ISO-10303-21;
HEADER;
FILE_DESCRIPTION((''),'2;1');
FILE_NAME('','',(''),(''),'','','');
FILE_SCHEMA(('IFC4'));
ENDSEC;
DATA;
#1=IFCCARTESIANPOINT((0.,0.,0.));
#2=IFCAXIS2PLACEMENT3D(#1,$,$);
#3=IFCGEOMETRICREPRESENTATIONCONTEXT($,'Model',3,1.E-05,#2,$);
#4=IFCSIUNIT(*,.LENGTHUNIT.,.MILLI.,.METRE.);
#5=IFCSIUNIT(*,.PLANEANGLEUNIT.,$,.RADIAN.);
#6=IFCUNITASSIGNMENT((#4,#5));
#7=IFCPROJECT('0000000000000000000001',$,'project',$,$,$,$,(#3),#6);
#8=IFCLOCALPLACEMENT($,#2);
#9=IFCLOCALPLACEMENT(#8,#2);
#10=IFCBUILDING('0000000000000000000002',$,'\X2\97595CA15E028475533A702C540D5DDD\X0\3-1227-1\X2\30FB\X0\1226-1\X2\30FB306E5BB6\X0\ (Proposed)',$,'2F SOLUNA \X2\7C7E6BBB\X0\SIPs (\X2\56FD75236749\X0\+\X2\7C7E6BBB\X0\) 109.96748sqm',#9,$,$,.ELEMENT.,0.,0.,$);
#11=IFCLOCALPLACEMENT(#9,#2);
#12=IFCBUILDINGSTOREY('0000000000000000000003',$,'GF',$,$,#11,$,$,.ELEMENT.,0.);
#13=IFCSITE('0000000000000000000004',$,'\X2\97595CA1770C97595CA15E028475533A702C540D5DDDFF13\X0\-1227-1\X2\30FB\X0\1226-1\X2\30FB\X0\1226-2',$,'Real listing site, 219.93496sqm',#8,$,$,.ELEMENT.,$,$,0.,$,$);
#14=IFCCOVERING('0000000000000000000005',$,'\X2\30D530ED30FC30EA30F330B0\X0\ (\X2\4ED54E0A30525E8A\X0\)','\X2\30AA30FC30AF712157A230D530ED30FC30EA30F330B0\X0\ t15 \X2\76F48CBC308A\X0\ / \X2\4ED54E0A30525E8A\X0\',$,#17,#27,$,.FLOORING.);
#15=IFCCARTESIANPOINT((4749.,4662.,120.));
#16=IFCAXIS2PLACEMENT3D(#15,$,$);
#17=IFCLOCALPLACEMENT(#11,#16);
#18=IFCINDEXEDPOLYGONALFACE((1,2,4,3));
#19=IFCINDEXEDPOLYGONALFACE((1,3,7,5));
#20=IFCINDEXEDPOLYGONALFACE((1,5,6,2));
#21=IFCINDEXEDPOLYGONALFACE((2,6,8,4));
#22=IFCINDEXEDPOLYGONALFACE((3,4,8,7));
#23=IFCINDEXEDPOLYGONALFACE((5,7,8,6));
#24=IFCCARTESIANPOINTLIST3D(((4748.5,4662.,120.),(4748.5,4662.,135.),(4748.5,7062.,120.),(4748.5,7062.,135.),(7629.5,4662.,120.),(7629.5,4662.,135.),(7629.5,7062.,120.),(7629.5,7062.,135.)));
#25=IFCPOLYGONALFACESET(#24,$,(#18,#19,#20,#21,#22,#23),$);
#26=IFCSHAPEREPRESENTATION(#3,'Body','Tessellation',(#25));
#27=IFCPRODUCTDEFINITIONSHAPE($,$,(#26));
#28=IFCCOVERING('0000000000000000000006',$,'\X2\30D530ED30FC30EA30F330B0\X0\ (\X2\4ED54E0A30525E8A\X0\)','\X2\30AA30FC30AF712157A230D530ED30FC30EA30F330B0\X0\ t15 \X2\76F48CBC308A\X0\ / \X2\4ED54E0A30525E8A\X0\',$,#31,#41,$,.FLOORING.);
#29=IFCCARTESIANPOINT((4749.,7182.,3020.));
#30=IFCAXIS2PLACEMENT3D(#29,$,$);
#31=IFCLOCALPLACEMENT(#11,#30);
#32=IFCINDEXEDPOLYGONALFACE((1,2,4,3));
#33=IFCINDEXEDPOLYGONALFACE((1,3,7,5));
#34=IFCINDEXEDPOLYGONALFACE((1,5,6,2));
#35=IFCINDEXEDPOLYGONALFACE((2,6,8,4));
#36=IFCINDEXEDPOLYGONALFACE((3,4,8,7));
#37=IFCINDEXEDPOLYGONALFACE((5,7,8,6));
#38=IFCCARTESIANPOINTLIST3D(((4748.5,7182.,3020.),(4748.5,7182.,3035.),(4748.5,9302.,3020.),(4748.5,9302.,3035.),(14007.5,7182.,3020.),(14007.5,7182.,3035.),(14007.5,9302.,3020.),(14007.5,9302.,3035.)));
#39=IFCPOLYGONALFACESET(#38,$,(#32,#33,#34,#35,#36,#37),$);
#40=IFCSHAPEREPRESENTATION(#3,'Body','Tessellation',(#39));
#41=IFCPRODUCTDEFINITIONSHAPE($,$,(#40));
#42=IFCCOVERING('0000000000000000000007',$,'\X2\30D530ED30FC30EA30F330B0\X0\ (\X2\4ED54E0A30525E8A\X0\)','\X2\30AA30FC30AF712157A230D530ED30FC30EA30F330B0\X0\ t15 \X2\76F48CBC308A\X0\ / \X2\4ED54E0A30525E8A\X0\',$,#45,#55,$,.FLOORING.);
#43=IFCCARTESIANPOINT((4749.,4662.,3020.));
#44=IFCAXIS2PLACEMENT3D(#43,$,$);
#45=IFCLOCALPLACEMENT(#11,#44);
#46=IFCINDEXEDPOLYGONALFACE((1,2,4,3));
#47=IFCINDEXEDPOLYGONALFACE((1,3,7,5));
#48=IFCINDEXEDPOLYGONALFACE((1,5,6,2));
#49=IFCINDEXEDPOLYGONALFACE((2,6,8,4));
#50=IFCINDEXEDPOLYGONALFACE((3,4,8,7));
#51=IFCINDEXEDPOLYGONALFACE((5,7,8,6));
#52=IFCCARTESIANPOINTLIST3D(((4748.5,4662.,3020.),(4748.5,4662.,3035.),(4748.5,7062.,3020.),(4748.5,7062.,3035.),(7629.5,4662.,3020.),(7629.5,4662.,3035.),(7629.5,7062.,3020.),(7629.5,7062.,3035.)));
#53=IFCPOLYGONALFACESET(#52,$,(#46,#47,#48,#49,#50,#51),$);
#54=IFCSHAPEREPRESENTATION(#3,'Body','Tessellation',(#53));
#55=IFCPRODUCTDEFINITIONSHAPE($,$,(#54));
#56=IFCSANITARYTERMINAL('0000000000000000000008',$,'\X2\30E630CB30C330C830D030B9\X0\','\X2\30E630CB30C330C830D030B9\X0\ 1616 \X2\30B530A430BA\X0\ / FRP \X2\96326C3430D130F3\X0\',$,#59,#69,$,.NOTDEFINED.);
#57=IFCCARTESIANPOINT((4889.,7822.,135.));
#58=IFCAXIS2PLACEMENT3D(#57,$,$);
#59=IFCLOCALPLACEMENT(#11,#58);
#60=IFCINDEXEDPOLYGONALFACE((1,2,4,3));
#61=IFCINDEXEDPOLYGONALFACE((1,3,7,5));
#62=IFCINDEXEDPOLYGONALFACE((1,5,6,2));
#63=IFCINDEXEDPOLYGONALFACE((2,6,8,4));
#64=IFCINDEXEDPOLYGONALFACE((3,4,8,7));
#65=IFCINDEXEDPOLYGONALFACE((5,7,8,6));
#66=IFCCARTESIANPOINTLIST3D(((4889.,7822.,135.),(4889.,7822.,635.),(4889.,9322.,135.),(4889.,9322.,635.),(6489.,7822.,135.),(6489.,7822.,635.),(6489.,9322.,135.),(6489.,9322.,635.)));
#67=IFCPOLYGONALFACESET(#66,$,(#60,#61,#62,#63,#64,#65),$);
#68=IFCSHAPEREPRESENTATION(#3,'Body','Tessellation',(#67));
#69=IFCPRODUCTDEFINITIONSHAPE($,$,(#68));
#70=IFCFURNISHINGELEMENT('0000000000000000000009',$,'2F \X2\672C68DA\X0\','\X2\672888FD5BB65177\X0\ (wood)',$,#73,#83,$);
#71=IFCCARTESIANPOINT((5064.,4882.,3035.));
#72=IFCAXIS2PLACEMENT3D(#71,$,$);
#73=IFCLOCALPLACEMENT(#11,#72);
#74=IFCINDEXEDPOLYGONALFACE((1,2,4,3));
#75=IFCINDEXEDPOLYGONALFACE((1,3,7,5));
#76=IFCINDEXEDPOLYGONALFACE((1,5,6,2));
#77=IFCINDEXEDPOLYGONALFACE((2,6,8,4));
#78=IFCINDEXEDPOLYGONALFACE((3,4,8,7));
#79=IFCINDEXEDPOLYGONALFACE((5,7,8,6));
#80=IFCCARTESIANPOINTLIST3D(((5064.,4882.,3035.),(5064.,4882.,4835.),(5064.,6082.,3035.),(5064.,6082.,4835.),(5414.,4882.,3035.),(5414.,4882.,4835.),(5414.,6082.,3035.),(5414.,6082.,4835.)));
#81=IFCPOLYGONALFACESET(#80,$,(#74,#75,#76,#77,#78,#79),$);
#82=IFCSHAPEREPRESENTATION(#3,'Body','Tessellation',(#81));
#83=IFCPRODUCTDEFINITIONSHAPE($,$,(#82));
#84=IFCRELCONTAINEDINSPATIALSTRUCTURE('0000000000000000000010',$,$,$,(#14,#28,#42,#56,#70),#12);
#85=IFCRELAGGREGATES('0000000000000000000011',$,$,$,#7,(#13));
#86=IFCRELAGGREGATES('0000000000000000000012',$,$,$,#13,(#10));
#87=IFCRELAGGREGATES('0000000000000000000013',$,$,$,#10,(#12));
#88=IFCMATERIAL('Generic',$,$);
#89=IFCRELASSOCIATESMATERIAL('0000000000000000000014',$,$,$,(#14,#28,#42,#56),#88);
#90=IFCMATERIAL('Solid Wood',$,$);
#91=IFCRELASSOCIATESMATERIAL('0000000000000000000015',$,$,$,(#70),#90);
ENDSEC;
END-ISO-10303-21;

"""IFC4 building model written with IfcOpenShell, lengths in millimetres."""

from ifc_helpers import new_model, si_unit, frame, frame_2d, origin, place, context, project, spatial, rectangle, extrude, material, element, save


model = new_model("IFC4")

# Units and contexts
model_context = context("Model", 3, precision=1e-05, world=origin())
ifc_project = project(units=[si_unit("LENGTHUNIT", "METRE", prefix="MILLI"), si_unit("PLANEANGLEUNIT", "RADIAN")], contexts=[model_context])

# Site, building, storey
site_placement = place(None, origin())
site = spatial("IfcSite", under=ifc_project, at=site_placement, Name="静岡県静岡市葵区瀬名川３-1227-1・1226-1・1226-2", ObjectType="Real listing site, 219.93496sqm", CompositionType="ELEMENT", RefElevation=0.0)
building_placement = place(site_placement, origin())
building = spatial("IfcBuilding", under=site, at=building_placement, Name="静岡市葵区瀬名川3-1227-1・1226-1・の家 (Proposed)", ObjectType="2F SOLUNA 籾殻SIPs (国産杉+籾殻) 109.96748sqm", CompositionType="ELEMENT", ElevationOfRefHeight=0.0, ElevationOfTerrain=0.0)
storey_placement = place(building_placement, origin())
storey = spatial("IfcBuildingStorey", under=building, at=storey_placement, Name="GF", CompositionType="ELEMENT", Elevation=0.0)

# Shared definitions
ifc_material_1 = material(Name="Solid Wood")

# Coverings
ifc_material_2 = material(Name="Generic")
covering_1_placement = place(storey_placement, frame((4749.0, 4662.0, 120.0)))
element("IfcCovering", 1, at=covering_1_placement, inside=storey, material=ifc_material_2, Name="フローリング (仕上げ床)", Description="オーク無垢フローリング t15 直貼り / 仕上げ床", PredefinedType="FLOORING", context=model_context, shape_type="SweptSolid", body=[
    extrude(rectangle(XDim=2881.0, YDim=2400.0, at=frame_2d((1440.0, 1200.0))), frame((4749.0, 4662.0, 120.0)), (0.0, 0.0, 1.0), 15.0),
])
covering_2_placement = place(storey_placement, frame((4749.0, 7182.0, 3020.0)))
element("IfcCovering", 2, at=covering_2_placement, inside=storey, material=ifc_material_2, Name="フローリング (仕上げ床)", Description="オーク無垢フローリング t15 直貼り / 仕上げ床", PredefinedType="FLOORING", context=model_context, shape_type="SweptSolid", body=[
    extrude(rectangle(XDim=9259.0, YDim=2120.0, at=frame_2d((4629.0, 1060.0))), frame((4749.0, 7182.0, 3020.0)), (0.0, 0.0, 1.0), 15.0),
])
covering_3_placement = place(storey_placement, frame((4749.0, 4662.0, 3020.0)))
element("IfcCovering", 3, at=covering_3_placement, inside=storey, material=ifc_material_2, Name="フローリング (仕上げ床)", Description="オーク無垢フローリング t15 直貼り / 仕上げ床", PredefinedType="FLOORING", context=model_context, shape_type="SweptSolid", body=[
    extrude(rectangle(XDim=2881.0, YDim=2400.0, at=frame_2d((1440.0, 1200.0))), frame((4749.0, 4662.0, 3020.0)), (0.0, 0.0, 1.0), 15.0),
])

# Sanitary terminal
sanitary_terminal_placement = place(storey_placement, frame((4889.0, 7822.0, 135.0)))
element("IfcSanitaryTerminal", 4, at=sanitary_terminal_placement, inside=storey, material=ifc_material_2, Name="ユニットバス", Description="ユニットバス 1616 サイズ / FRP 防水パン", PredefinedType="NOTDEFINED", context=model_context, shape_type="SweptSolid", body=[
    extrude(rectangle(XDim=1600.0, YDim=1500.0, at=frame_2d((800.0, 750.0))), frame((4889.0, 7822.0, 135.0)), (0.0, 0.0, 1.0), 500.0),
])

# Furnishing element
furnishing_placement = place(storey_placement, frame((5064.0, 4882.0, 3035.0)))
element("IfcFurnishingElement", 5, at=furnishing_placement, inside=storey, material=ifc_material_1, Name="2F 本棚", Description="木製家具 (wood)", context=model_context, shape_type="SweptSolid", body=[
    extrude(rectangle(XDim=350.0, YDim=1200.0, at=frame_2d((175.0, 600.0))), frame((5064.0, 4882.0, 3035.0)), (0.0, 0.0, 1.0), 1800.0),
])

save(model, "model.ifc")
